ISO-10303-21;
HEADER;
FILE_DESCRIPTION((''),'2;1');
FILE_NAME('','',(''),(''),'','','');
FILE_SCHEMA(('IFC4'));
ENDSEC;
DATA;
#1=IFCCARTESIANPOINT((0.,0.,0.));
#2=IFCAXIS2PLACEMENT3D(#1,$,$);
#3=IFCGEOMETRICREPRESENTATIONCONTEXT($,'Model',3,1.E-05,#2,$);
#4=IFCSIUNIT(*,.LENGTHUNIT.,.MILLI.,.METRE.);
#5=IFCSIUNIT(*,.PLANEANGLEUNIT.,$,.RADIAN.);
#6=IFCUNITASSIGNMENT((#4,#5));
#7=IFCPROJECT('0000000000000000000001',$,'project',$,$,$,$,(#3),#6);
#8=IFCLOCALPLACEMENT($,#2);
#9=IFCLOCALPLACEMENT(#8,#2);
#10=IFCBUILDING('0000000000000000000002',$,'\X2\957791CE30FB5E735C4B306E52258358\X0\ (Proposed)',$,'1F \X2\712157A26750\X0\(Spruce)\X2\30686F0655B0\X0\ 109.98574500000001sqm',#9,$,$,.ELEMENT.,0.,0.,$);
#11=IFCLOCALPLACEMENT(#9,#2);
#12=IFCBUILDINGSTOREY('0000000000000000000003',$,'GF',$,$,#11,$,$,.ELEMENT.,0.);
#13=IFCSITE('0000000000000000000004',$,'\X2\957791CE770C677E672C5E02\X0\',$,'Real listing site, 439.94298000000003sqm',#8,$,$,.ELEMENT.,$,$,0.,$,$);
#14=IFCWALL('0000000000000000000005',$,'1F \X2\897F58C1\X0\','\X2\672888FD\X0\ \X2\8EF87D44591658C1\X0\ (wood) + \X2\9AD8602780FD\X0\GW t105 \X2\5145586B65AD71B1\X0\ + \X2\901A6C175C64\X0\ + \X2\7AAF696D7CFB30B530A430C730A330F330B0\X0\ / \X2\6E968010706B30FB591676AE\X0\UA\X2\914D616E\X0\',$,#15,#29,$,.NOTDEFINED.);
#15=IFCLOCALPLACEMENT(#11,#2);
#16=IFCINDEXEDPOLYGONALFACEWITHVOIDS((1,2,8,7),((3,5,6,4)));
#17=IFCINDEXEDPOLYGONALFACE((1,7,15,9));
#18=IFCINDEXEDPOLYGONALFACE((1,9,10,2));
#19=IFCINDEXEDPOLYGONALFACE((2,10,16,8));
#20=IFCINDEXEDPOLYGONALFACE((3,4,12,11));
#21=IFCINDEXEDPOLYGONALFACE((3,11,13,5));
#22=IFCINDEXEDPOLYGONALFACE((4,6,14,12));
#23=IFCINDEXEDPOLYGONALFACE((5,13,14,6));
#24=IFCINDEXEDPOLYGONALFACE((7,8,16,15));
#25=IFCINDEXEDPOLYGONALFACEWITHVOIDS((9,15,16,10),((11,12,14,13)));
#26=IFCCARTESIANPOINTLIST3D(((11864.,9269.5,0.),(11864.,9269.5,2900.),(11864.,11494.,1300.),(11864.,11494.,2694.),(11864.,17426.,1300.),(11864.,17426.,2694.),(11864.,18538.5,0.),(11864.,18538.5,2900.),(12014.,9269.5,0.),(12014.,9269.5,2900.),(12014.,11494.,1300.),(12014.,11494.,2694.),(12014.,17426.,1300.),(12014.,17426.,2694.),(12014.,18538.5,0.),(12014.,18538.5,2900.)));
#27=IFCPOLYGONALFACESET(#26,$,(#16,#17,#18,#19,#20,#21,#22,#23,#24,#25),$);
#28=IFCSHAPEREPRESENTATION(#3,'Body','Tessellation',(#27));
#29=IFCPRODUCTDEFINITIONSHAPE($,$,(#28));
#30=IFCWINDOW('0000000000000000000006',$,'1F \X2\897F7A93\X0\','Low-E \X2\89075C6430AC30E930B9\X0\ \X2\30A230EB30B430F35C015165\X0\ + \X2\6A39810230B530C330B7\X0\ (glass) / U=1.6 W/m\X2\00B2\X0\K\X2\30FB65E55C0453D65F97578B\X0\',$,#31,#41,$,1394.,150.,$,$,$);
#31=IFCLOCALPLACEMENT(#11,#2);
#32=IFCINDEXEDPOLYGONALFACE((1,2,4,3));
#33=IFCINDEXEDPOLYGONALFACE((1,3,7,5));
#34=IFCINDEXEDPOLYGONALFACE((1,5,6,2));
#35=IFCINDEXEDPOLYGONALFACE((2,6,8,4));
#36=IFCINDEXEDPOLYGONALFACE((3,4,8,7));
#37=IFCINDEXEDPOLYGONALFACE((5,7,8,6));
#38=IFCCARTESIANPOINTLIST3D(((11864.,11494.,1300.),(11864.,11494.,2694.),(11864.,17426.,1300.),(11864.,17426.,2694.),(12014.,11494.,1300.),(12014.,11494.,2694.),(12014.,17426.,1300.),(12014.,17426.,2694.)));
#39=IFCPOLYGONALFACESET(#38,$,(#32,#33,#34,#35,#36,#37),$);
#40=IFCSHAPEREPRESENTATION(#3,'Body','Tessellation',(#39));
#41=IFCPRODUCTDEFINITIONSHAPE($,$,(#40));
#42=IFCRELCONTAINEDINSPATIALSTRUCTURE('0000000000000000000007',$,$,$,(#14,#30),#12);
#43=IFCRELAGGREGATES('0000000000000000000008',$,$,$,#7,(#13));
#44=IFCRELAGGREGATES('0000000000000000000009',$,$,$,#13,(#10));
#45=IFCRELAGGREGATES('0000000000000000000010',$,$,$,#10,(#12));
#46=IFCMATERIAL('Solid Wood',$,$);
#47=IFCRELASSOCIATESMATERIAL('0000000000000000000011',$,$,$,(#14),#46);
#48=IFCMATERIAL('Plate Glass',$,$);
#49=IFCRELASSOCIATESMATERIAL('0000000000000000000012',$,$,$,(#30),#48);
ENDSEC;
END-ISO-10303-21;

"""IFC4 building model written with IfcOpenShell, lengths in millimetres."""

from ifc_helpers import new_model, si_unit, frame, frame_2d, origin, place, context, project, spatial, rectangle, extrude, material, element, fill, save


model = new_model("IFC4")

# Units and contexts
model_context = context("Model", 3, precision=1e-05, world=origin())
ifc_project = project(units=[si_unit("LENGTHUNIT", "METRE", prefix="MILLI"), si_unit("PLANEANGLEUNIT", "RADIAN")], contexts=[model_context])

# Site, building, storey
site_placement = place(None, origin())
site = spatial("IfcSite", under=ifc_project, at=site_placement, Name="長野県松本市", ObjectType="Real listing site, 439.94298000000003sqm", CompositionType="ELEMENT", RefElevation=0.0)
building_placement = place(site_placement, origin())
building = spatial("IfcBuilding", under=site, at=building_placement, Name="長野・平屋の別荘 (Proposed)", ObjectType="1F 無垢材(Spruce)と漆喰 109.98574500000001sqm", CompositionType="ELEMENT", ElevationOfRefHeight=0.0, ElevationOfTerrain=0.0)
storey_placement = place(building_placement, origin())
storey = spatial("IfcBuildingStorey", under=building, at=storey_placement, Name="GF", CompositionType="ELEMENT", Elevation=0.0)

# Shared definitions
ifc_material_1 = material(Name="Solid Wood")

# Shared definitions
ifc_material_2 = material(Name="Plate Glass")

# Wall, opening, window
wall_1_placement = place(storey_placement, frame((5932.0, 4635.0, 0.0)))
wall_1 = element("IfcWall", 1, at=wall_1_placement, inside=storey, material=ifc_material_1, Name="1F 西壁", Description="木製 軸組外壁 (wood) + 高性能GW t105 充填断熱 + 通気層 + 窯業系サイディング / 準耐火・外皮UA配慮", PredefinedType="NOTDEFINED", context=model_context, shape_type="SweptSolid", body=[
    extrude(rectangle(XDim=150.0, YDim=9269.0, at=frame_2d((75.0, 4634.0))), frame((5932.0, 4635.0, 0.0)), (0.0, 0.0, 1.0), 2900.0),
])
opening_1_placement = place(storey_placement, frame((5932.0, 5747.0, 650.0)))
opening_1 = element("IfcOpeningElement", 2, at=opening_1_placement, cuts=wall_1, PredefinedType="NOTDEFINED", context=model_context, shape_type="SweptSolid", body=[
    extrude(rectangle(XDim=150.0, YDim=5932.0, at=frame_2d((75.0, 2966.0))), frame((5932.0, 5747.0, 650.0)), (0.0, 0.0, 1.0), 1394.0),
])
window_1_placement = place(storey_placement, frame((5932.0, 5747.0, 650.0)))
window_1 = element("IfcWindow", 3, at=window_1_placement, inside=storey, material=ifc_material_2, Name="1F 西窓", Description="Low-E 複層ガラス アルゴン封入 + 樹脂サッシ (glass) / U=1.6 W/m²K・日射取得型", OverallHeight=1394.0, OverallWidth=150.0, context=model_context, shape_type="SweptSolid", body=[
    extrude(rectangle(XDim=150.0, YDim=5932.0, at=frame_2d((75.0, 2966.0))), frame((5932.0, 5747.0, 650.0)), (0.0, 0.0, 1.0), 1394.0),
])
fill(opening_1, window_1)

save(model, "model.ifc")
